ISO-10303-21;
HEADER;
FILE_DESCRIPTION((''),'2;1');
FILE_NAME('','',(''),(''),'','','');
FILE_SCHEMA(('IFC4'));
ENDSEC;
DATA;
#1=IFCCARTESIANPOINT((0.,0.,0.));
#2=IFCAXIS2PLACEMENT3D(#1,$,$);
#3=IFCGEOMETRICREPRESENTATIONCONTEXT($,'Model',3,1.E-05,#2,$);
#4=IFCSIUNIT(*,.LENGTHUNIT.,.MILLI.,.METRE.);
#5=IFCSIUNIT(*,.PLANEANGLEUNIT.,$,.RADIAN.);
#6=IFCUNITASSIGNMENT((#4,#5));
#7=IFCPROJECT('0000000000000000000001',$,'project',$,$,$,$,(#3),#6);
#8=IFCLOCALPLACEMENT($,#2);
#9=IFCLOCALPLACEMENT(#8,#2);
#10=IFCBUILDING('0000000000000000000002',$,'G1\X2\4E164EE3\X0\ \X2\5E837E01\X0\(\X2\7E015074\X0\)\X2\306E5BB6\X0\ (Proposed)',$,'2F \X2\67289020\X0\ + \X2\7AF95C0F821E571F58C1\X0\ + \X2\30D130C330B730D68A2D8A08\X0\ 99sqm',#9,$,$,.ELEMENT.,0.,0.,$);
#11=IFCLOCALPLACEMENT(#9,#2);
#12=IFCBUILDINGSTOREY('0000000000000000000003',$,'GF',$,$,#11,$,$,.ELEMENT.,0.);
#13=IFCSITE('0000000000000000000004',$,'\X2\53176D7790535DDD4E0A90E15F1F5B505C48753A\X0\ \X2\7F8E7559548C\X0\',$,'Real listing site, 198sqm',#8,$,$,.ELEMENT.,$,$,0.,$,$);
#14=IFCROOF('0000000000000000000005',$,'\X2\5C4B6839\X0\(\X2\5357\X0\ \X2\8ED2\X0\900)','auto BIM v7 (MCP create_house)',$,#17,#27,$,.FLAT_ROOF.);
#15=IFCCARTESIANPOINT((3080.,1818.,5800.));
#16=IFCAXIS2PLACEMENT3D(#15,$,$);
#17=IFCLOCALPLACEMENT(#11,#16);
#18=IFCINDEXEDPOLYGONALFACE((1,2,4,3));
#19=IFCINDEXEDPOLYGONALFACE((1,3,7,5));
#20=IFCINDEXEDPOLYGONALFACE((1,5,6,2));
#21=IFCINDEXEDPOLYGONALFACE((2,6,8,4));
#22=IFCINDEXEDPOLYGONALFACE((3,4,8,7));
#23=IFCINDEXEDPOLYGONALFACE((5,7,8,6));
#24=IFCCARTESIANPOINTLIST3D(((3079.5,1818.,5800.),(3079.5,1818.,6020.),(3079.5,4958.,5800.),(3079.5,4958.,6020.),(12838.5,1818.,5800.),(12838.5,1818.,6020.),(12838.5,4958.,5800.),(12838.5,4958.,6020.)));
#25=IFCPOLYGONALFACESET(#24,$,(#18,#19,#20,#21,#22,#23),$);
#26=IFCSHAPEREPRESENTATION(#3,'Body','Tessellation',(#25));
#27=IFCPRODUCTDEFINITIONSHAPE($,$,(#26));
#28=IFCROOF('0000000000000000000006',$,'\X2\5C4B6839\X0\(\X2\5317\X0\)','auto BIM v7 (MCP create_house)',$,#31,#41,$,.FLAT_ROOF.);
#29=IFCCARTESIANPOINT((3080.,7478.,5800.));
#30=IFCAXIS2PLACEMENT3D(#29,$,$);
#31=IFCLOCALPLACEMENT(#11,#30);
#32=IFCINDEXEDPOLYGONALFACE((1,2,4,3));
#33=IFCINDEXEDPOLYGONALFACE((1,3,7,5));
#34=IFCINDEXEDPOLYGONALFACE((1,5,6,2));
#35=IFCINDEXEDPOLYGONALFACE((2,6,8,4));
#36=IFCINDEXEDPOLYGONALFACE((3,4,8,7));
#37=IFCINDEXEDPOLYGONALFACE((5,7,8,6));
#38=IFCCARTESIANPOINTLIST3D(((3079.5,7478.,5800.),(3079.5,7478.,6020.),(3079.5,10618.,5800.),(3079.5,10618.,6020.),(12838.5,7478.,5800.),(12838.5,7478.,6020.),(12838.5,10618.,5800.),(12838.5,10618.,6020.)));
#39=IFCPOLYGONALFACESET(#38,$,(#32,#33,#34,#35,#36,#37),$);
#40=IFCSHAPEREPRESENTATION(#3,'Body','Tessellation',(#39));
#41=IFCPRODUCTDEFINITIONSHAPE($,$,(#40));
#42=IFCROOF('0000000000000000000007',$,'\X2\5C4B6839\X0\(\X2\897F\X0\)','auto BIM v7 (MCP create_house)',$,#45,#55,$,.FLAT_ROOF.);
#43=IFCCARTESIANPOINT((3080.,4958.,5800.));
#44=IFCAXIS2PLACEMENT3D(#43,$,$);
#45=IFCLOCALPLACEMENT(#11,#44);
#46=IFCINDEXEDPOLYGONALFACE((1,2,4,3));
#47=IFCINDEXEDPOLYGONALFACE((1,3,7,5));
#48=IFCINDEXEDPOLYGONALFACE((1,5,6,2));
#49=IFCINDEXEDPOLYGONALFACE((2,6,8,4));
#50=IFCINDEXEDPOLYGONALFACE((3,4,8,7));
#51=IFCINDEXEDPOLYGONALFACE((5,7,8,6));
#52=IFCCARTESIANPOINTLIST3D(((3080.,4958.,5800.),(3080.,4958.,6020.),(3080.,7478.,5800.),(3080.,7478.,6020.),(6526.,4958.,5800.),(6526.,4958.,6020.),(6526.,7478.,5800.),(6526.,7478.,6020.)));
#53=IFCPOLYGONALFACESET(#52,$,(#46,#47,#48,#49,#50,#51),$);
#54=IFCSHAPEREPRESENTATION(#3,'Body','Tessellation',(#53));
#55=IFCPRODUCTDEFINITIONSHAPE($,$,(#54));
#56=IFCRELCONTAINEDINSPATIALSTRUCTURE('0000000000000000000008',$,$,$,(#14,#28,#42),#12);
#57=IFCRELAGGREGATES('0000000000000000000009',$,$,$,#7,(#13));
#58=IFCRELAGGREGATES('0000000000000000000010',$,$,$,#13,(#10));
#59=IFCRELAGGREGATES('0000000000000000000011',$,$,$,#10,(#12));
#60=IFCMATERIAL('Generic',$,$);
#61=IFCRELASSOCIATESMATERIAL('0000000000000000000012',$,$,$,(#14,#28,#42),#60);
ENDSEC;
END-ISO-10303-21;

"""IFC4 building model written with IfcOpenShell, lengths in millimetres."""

from ifc_helpers import new_model, si_unit, frame, frame_2d, origin, place, context, project, spatial, rectangle, extrude, material, element, save


model = new_model("IFC4")

# Units and contexts
model_context = context("Model", 3, precision=1e-05, world=origin())
ifc_project = project(units=[si_unit("LENGTHUNIT", "METRE", prefix="MILLI"), si_unit("PLANEANGLEUNIT", "RADIAN")], contexts=[model_context])

# Site, building, storey
site_placement = place(None, origin())
site = spatial("IfcSite", under=ifc_project, at=site_placement, Name="北海道川上郡弟子屈町 美留和", ObjectType="Real listing site, 198sqm", CompositionType="ELEMENT", RefElevation=0.0)
building_placement = place(site_placement, origin())
building = spatial("IfcBuilding", under=site, at=building_placement, Name="G1世代 広縁(縁側)の家 (Proposed)", ObjectType="2F 木造 + 竹小舞土壁 + パッシブ設計 99sqm", CompositionType="ELEMENT", ElevationOfRefHeight=0.0, ElevationOfTerrain=0.0)
storey_placement = place(building_placement, origin())
storey = spatial("IfcBuildingStorey", under=building, at=storey_placement, Name="GF", CompositionType="ELEMENT", Elevation=0.0)

# Shared definitions
ifc_material = material(Name="Generic")

# Roofs
roof_1_placement = place(storey_placement, frame((3080.0, 1818.0, 5800.0)))
element("IfcRoof", 1, at=roof_1_placement, inside=storey, material=ifc_material, Name="屋根(南 軒900)", Description="auto BIM v7 (MCP create_house)", PredefinedType="FLAT_ROOF", context=model_context, shape_type="SweptSolid", body=[
    extrude(rectangle(XDim=9759.0, YDim=3140.0, at=frame_2d((4879.0, 1570.0))), frame((3080.0, 1818.0, 5800.0)), (0.0, 0.0, 1.0), 220.0),
])
roof_2_placement = place(storey_placement, frame((3080.0, 7478.0, 5800.0)))
element("IfcRoof", 2, at=roof_2_placement, inside=storey, material=ifc_material, Name="屋根(北)", Description="auto BIM v7 (MCP create_house)", PredefinedType="FLAT_ROOF", context=model_context, shape_type="SweptSolid", body=[
    extrude(rectangle(XDim=9759.0, YDim=3140.0, at=frame_2d((4879.0, 1570.0))), frame((3080.0, 7478.0, 5800.0)), (0.0, 0.0, 1.0), 220.0),
])
roof_3_placement = place(storey_placement, frame((3080.0, 4958.0, 5800.0)))
element("IfcRoof", 3, at=roof_3_placement, inside=storey, material=ifc_material, Name="屋根(西)", Description="auto BIM v7 (MCP create_house)", PredefinedType="FLAT_ROOF", context=model_context, shape_type="SweptSolid", body=[
    extrude(rectangle(XDim=3446.0, YDim=2520.0, at=frame_2d((1723.0, 1260.0))), frame((3080.0, 4958.0, 5800.0)), (0.0, 0.0, 1.0), 220.0),
])

save(model, "model.ifc")
